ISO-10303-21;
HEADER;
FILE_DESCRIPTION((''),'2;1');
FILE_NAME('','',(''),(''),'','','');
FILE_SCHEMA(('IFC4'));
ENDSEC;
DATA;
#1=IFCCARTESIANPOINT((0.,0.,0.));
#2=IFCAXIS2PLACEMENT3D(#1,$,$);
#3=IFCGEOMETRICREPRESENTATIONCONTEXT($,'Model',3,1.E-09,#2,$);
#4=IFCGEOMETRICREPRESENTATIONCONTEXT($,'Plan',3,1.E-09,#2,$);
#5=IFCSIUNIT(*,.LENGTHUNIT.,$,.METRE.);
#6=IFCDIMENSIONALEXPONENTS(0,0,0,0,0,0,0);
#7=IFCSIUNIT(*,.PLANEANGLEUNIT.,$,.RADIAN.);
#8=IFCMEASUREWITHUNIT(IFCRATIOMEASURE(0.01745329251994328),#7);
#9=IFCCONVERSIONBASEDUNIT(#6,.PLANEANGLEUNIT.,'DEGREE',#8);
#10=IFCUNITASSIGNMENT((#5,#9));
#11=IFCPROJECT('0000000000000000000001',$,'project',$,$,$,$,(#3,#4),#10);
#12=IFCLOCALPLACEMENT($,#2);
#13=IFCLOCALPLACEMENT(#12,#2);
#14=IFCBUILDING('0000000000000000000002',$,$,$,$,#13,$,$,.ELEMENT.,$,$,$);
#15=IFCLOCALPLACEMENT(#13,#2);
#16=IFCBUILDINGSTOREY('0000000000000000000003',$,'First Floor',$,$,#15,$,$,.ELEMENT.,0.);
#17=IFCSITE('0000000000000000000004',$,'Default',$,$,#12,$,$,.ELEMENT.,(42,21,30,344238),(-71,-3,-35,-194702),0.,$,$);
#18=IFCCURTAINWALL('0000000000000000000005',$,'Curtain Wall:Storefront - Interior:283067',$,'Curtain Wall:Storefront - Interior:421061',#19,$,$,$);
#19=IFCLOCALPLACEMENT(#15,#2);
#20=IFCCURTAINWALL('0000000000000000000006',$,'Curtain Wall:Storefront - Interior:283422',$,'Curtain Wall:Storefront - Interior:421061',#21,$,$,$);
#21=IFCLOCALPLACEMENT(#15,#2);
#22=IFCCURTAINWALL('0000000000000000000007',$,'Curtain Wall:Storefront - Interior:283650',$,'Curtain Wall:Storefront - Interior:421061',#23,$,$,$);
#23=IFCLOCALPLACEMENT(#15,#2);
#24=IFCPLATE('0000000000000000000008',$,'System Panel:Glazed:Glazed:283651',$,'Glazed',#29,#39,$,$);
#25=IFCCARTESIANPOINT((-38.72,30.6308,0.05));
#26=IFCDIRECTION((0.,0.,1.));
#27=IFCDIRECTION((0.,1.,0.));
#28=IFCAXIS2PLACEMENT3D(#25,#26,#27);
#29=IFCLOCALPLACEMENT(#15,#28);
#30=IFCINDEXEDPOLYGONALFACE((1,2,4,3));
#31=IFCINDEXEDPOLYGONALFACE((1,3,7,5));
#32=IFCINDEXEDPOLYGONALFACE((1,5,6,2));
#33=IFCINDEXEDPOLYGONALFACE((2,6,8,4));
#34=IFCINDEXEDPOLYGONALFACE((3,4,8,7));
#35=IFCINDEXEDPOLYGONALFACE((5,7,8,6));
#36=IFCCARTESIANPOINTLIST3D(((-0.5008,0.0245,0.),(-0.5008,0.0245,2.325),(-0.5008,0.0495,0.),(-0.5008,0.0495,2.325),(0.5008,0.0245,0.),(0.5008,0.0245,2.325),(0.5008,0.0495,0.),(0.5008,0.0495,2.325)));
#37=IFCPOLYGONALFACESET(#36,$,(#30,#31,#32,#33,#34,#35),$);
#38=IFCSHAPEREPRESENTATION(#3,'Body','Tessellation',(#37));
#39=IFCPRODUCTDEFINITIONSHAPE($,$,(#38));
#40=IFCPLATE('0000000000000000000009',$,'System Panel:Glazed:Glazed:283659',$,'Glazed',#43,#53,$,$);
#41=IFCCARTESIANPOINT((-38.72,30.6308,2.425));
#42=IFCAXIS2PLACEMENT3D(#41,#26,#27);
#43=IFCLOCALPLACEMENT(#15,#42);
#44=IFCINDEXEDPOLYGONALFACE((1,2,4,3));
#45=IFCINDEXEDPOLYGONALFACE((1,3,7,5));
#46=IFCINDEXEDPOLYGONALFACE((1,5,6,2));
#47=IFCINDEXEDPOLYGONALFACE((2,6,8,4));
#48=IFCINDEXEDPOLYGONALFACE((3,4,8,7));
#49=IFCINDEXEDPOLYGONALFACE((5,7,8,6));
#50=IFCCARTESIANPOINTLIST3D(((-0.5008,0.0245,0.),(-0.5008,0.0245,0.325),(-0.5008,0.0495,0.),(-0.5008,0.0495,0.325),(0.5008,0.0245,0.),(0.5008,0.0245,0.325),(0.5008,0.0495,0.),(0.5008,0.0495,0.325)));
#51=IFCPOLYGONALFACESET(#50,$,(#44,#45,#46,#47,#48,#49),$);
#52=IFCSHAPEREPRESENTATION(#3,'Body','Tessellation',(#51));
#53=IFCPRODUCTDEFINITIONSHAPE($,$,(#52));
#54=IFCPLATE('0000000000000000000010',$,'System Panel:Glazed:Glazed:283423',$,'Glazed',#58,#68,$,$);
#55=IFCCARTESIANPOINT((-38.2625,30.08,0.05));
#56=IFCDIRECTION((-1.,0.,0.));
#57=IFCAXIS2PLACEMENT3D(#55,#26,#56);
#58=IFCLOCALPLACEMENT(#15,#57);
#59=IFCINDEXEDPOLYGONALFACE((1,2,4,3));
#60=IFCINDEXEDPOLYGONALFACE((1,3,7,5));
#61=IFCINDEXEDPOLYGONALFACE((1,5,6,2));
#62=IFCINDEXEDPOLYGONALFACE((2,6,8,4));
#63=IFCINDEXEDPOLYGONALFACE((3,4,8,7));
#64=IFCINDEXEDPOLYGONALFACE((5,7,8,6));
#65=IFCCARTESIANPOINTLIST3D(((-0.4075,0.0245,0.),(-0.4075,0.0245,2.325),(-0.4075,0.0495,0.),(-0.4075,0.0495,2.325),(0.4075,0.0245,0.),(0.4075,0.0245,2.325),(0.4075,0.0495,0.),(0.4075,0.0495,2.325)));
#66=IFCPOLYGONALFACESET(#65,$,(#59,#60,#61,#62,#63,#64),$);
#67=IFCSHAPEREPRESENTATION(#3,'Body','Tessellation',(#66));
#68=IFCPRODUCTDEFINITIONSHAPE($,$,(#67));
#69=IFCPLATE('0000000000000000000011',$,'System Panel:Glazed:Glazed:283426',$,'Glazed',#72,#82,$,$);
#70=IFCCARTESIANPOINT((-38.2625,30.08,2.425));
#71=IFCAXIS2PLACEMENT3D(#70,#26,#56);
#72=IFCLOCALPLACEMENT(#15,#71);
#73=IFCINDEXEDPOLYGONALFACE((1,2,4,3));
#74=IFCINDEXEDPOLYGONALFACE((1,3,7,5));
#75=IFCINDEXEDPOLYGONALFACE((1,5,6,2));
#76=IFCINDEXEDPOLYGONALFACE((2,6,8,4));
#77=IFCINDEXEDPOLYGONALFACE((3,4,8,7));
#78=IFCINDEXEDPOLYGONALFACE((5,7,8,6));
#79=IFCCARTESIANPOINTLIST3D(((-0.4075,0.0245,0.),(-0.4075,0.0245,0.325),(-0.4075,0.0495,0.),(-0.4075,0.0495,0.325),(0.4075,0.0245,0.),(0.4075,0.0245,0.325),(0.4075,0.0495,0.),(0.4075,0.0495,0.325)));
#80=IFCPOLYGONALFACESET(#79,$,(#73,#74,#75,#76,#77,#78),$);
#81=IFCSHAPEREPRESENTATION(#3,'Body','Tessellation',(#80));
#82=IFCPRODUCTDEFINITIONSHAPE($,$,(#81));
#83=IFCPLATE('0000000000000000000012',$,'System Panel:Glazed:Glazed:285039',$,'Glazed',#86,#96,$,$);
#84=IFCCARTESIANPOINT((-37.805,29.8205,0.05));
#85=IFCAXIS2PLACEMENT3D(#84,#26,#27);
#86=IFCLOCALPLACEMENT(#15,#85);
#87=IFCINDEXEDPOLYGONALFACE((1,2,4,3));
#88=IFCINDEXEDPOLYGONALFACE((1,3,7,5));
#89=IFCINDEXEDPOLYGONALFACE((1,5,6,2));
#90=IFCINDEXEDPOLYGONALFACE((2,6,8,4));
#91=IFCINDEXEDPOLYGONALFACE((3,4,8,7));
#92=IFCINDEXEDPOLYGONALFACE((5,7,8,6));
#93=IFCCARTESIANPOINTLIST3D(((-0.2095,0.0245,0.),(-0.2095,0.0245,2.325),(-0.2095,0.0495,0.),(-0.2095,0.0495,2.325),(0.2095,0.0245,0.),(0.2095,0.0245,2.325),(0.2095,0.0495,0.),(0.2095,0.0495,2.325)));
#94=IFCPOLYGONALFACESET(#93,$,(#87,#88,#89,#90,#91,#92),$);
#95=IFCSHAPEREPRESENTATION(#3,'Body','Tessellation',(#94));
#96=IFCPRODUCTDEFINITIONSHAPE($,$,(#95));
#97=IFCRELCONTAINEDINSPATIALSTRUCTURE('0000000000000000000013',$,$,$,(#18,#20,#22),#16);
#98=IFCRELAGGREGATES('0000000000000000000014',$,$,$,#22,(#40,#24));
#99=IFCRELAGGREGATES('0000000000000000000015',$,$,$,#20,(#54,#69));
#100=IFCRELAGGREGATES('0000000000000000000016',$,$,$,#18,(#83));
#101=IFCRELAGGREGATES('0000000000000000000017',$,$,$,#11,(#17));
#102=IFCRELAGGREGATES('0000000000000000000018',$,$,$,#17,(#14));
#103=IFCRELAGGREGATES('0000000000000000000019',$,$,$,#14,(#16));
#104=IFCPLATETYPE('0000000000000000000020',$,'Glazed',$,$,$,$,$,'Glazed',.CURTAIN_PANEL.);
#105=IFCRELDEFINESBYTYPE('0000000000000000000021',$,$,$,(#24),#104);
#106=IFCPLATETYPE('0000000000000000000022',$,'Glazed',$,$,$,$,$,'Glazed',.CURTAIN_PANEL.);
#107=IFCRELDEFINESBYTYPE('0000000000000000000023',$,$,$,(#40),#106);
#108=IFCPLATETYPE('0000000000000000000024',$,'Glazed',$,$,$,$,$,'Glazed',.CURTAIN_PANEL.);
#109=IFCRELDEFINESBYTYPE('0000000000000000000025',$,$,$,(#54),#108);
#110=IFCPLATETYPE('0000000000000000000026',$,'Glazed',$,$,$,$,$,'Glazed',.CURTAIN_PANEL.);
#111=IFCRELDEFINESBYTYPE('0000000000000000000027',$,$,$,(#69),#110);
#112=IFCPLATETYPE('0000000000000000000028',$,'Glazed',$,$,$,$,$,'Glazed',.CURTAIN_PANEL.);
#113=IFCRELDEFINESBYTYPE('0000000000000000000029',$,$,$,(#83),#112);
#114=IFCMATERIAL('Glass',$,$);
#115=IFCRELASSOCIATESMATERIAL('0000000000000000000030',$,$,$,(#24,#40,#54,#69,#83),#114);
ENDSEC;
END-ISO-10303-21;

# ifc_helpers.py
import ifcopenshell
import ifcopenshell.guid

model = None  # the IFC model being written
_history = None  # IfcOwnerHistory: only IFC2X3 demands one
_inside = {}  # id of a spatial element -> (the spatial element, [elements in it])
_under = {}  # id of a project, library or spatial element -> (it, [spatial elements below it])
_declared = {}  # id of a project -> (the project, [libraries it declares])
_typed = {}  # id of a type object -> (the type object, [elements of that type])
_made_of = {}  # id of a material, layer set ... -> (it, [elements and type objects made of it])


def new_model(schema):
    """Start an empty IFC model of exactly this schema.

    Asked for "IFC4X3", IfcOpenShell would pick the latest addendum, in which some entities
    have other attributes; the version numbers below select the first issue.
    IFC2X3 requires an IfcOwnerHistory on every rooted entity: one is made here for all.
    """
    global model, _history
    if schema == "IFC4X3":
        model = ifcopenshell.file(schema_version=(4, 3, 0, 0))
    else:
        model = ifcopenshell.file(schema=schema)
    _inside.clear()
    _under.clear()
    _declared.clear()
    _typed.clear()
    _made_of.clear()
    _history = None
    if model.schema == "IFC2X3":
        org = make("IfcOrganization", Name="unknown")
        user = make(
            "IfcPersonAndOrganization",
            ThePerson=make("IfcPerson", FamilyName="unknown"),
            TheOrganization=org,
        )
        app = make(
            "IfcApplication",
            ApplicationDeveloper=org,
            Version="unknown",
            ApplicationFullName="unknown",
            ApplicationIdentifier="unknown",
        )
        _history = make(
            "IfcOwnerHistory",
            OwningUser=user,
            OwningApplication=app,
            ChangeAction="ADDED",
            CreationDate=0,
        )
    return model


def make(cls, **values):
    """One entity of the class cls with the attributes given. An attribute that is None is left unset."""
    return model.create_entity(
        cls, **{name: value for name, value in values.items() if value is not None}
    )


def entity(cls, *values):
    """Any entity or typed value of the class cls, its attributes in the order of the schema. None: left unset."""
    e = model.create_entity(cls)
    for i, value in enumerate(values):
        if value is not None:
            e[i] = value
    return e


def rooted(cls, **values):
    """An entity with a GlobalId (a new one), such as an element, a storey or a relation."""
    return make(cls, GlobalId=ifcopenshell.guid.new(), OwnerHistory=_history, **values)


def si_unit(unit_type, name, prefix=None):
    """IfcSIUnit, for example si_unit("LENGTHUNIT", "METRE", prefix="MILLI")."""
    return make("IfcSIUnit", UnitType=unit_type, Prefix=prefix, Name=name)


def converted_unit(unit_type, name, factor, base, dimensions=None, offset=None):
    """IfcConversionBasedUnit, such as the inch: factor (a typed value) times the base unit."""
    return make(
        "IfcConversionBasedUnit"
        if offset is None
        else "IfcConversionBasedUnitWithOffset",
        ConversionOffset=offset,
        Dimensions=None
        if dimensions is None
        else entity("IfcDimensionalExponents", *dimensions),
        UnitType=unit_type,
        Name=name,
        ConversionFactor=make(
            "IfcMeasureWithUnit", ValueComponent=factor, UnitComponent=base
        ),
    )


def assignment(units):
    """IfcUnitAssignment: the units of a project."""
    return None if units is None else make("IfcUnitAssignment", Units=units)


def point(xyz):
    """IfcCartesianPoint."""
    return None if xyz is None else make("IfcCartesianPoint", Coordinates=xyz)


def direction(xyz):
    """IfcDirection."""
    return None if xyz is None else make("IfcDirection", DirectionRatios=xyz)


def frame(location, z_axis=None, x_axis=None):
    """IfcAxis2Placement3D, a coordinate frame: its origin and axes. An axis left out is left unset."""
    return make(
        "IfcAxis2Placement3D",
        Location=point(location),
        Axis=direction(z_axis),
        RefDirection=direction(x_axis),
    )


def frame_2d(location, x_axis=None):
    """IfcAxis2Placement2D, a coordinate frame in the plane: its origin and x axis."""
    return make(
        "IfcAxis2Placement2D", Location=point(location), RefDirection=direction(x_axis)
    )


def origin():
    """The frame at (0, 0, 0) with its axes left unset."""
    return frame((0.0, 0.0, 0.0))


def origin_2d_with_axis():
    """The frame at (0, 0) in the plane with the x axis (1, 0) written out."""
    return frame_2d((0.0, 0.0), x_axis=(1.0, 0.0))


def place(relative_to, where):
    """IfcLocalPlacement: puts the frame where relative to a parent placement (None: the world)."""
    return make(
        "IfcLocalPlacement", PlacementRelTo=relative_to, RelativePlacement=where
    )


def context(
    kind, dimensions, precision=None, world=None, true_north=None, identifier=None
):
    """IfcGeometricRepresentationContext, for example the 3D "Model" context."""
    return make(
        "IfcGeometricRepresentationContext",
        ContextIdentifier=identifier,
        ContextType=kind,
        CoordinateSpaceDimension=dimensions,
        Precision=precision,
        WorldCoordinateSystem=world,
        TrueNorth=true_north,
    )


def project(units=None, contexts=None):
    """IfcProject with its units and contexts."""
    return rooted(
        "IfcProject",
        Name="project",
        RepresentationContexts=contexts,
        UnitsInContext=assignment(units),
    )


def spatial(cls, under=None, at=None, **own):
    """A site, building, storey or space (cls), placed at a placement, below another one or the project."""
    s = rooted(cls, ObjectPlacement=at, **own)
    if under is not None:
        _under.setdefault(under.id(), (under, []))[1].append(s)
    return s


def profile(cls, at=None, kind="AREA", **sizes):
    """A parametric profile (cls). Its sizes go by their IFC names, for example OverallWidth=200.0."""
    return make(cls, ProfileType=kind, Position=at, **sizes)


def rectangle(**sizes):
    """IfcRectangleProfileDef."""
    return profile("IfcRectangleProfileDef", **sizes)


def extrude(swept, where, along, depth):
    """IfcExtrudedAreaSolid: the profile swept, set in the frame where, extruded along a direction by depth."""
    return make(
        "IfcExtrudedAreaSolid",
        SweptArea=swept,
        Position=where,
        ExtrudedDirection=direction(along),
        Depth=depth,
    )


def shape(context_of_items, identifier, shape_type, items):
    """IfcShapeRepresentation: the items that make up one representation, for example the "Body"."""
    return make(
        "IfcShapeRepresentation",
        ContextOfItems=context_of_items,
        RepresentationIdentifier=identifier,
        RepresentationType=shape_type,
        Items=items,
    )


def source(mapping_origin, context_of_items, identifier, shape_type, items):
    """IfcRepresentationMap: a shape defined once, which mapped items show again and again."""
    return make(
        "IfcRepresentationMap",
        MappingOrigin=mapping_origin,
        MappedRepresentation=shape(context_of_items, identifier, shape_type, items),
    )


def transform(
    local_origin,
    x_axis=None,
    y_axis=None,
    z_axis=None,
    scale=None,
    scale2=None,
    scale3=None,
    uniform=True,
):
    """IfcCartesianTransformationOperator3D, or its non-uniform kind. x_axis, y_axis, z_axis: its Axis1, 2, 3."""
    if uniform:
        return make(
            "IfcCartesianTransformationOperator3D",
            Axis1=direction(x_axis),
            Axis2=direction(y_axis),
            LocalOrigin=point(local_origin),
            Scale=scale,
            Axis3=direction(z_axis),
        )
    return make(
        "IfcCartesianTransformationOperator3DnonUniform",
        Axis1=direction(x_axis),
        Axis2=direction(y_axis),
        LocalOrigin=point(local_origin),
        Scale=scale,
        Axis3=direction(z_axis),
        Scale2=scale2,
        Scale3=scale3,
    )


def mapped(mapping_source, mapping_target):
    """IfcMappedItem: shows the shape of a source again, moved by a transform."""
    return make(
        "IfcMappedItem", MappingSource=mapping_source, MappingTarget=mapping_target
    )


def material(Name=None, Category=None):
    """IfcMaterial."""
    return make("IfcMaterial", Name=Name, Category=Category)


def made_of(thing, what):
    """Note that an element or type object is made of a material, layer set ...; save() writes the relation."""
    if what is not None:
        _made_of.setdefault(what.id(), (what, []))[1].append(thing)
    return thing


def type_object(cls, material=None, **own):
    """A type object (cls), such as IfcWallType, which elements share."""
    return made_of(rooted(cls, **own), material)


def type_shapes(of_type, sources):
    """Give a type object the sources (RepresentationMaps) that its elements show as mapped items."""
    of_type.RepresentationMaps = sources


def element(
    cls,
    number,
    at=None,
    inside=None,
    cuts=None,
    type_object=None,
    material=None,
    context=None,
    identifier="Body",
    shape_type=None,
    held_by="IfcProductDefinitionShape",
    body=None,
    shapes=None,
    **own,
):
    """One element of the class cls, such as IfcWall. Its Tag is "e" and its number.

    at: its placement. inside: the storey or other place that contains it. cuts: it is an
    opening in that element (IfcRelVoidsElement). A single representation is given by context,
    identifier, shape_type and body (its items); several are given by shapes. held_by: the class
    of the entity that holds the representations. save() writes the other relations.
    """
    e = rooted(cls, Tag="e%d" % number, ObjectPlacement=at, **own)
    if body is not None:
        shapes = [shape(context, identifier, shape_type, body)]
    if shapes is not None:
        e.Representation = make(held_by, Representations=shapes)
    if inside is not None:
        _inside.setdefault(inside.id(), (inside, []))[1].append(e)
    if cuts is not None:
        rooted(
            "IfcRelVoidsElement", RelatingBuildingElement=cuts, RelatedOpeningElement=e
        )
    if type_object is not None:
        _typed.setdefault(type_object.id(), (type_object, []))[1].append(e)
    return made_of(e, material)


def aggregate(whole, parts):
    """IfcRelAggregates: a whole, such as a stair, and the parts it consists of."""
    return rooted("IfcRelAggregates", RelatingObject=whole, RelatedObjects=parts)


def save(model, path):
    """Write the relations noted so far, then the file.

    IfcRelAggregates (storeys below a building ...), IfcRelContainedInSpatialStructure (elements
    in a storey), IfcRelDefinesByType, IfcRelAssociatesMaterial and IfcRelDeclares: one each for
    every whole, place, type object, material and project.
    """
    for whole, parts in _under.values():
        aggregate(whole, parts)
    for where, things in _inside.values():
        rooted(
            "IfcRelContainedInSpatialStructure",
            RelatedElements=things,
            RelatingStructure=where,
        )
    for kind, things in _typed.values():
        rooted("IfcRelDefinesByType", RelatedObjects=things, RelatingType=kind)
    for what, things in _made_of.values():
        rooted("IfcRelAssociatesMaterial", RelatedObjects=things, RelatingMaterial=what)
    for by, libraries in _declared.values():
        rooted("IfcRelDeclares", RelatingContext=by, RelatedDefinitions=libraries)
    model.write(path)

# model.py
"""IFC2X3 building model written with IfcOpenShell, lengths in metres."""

from ifc_helpers import new_model, entity, si_unit, converted_unit, frame, origin, origin_2d_with_axis, place, context, project, spatial, rectangle, extrude, source, transform, mapped, material, type_object, type_shapes, element, aggregate, save


model = new_model("IFC2X3")

# Units and contexts
model_context = context("Model", 3, precision=1e-09, world=origin())
plan_context = context("Plan", 3, precision=1e-09, world=origin())
ifc_project = project(units=[si_unit("LENGTHUNIT", "METRE"), converted_unit("PLANEANGLEUNIT", "DEGREE", entity("IfcRatioMeasure", 0.01745329251994328), si_unit("PLANEANGLEUNIT", "RADIAN"), dimensions=[0, 0, 0, 0, 0, 0, 0])], contexts=[model_context, plan_context])

# Site, building, storey
site_placement = place(None, origin())
site = spatial("IfcSite", under=ifc_project, at=site_placement, Name="Default", CompositionType="ELEMENT", RefLatitude=(42, 21, 30, 344238), RefLongitude=(-71, -3, -35, -194702), RefElevation=0.0)
building_placement = place(site_placement, origin())
building = spatial("IfcBuilding", under=site, at=building_placement, CompositionType="ELEMENT")
storey_placement = place(building_placement, origin())
storey = spatial("IfcBuildingStorey", under=building, at=storey_placement, Name="First Floor", CompositionType="ELEMENT", Elevation=0.0)

# Curtain walls
curtain_wall_1_placement = place(storey_placement, origin())
curtain_wall_1 = element("IfcCurtainWall", 1, at=curtain_wall_1_placement, inside=storey, Name="Curtain Wall:Storefront - Interior:283067", ObjectType="Curtain Wall:Storefront - Interior:421061")
curtain_wall_2_placement = place(storey_placement, origin())
curtain_wall_2 = element("IfcCurtainWall", 2, at=curtain_wall_2_placement, inside=storey, Name="Curtain Wall:Storefront - Interior:283422", ObjectType="Curtain Wall:Storefront - Interior:421061")

# Curtain wall
curtain_wall_3_placement = place(storey_placement, origin())
curtain_wall_3 = element("IfcCurtainWall", 3, at=curtain_wall_3_placement, inside=storey, Name="Curtain Wall:Storefront - Interior:283650", ObjectType="Curtain Wall:Storefront - Interior:421061")

# Plates
ifc_material_1 = material(Name="Glass")
plate_type_1 = type_object("IfcPlateType", Name="Glazed", ElementType="Glazed", PredefinedType="CURTAIN_PANEL")
shared_shape_1 = source(origin(), model_context, "Body", "SweptSolid", [
    extrude(rectangle(XDim=0.025, YDim=1.0017, at=origin_2d_with_axis()), frame((0.0, 0.037, 0.0), z_axis=(0.0, 0.0, 1.0), x_axis=(0.0, 1.0, 0.0)), (0.0, 0.0, 1.0), 2.325),
])
type_shapes(plate_type_1, [shared_shape_1])
plate_1_placement = place(storey_placement, frame((-38.72, 30.6308, 0.05), z_axis=(0.0, 0.0, 1.0), x_axis=(0.0, 1.0, 0.0)))
plate_1 = element("IfcPlate", 4, at=plate_1_placement, type_object=plate_type_1, material=ifc_material_1, Name="System Panel:Glazed:Glazed:283651", ObjectType="Glazed", context=model_context, shape_type="MappedRepresentation", body=[
    mapped(shared_shape_1, transform((0.0, 0.0, 0.0), scale=1.0)),
])
plate_type_2 = type_object("IfcPlateType", Name="Glazed", ElementType="Glazed", PredefinedType="CURTAIN_PANEL")
shared_shape_2 = source(origin(), model_context, "Body", "SweptSolid", [
    extrude(rectangle(XDim=0.025, YDim=1.0017, at=origin_2d_with_axis()), frame((0.0, 0.037, 0.0), z_axis=(0.0, 0.0, 1.0), x_axis=(0.0, 1.0, 0.0)), (0.0, 0.0, 1.0), 0.325),
])
type_shapes(plate_type_2, [shared_shape_2])
plate_2_placement = place(storey_placement, frame((-38.72, 30.6308, 2.425), z_axis=(0.0, 0.0, 1.0), x_axis=(0.0, 1.0, 0.0)))
plate_2 = element("IfcPlate", 5, at=plate_2_placement, type_object=plate_type_2, material=ifc_material_1, Name="System Panel:Glazed:Glazed:283659", ObjectType="Glazed", context=model_context, shape_type="MappedRepresentation", body=[
    mapped(shared_shape_2, transform((0.0, 0.0, 0.0), scale=1.0)),
])
aggregate(curtain_wall_3, [plate_2, plate_1])
plate_type_3 = type_object("IfcPlateType", Name="Glazed", ElementType="Glazed", PredefinedType="CURTAIN_PANEL")
shared_shape_3 = source(origin(), model_context, "Body", "SweptSolid", [
    extrude(rectangle(XDim=0.025, YDim=0.815, at=origin_2d_with_axis()), frame((0.0, 0.037, 0.0), z_axis=(0.0, 0.0, 1.0), x_axis=(0.0, 1.0, 0.0)), (0.0, 0.0, 1.0), 2.325),
])
type_shapes(plate_type_3, [shared_shape_3])
plate_3_placement = place(storey_placement, frame((-38.2625, 30.08, 0.05), z_axis=(0.0, 0.0, 1.0), x_axis=(-1.0, 0.0, 0.0)))
plate_3 = element("IfcPlate", 6, at=plate_3_placement, type_object=plate_type_3, material=ifc_material_1, Name="System Panel:Glazed:Glazed:283423", ObjectType="Glazed", context=model_context, shape_type="MappedRepresentation", body=[
    mapped(shared_shape_3, transform((0.0, 0.0, 0.0), scale=1.0)),
])
plate_type_4 = type_object("IfcPlateType", Name="Glazed", ElementType="Glazed", PredefinedType="CURTAIN_PANEL")
shared_shape_4 = source(origin(), model_context, "Body", "SweptSolid", [
    extrude(rectangle(XDim=0.025, YDim=0.815, at=origin_2d_with_axis()), frame((0.0, 0.037, 0.0), z_axis=(0.0, 0.0, 1.0), x_axis=(0.0, 1.0, 0.0)), (0.0, 0.0, 1.0), 0.325),
])
type_shapes(plate_type_4, [shared_shape_4])
plate_4_placement = place(storey_placement, frame((-38.2625, 30.08, 2.425), z_axis=(0.0, 0.0, 1.0), x_axis=(-1.0, 0.0, 0.0)))
plate_4 = element("IfcPlate", 7, at=plate_4_placement, type_object=plate_type_4, material=ifc_material_1, Name="System Panel:Glazed:Glazed:283426", ObjectType="Glazed", context=model_context, shape_type="MappedRepresentation", body=[
    mapped(shared_shape_4, transform((0.0, 0.0, 0.0), scale=1.0)),
])
aggregate(curtain_wall_2, [plate_3, plate_4])
plate_type_5 = type_object("IfcPlateType", Name="Glazed", ElementType="Glazed", PredefinedType="CURTAIN_PANEL")
shared_shape_5 = source(origin(), model_context, "Body", "SweptSolid", [
    extrude(rectangle(XDim=0.025, YDim=0.419, at=origin_2d_with_axis()), frame((0.0, 0.037, 0.0), z_axis=(0.0, 0.0, 1.0), x_axis=(0.0, 1.0, 0.0)), (0.0, 0.0, 1.0), 2.325),
])
type_shapes(plate_type_5, [shared_shape_5])
plate_5_placement = place(storey_placement, frame((-37.805, 29.8205, 0.05), z_axis=(0.0, 0.0, 1.0), x_axis=(0.0, 1.0, 0.0)))
plate_5 = element("IfcPlate", 8, at=plate_5_placement, type_object=plate_type_5, material=ifc_material_1, Name="System Panel:Glazed:Glazed:285039", ObjectType="Glazed", context=model_context, shape_type="MappedRepresentation", body=[
    mapped(shared_shape_5, transform((0.0, 0.0, 0.0), scale=1.0)),
])

aggregate(curtain_wall_1, [plate_5])

save(model, "model.ifc")
